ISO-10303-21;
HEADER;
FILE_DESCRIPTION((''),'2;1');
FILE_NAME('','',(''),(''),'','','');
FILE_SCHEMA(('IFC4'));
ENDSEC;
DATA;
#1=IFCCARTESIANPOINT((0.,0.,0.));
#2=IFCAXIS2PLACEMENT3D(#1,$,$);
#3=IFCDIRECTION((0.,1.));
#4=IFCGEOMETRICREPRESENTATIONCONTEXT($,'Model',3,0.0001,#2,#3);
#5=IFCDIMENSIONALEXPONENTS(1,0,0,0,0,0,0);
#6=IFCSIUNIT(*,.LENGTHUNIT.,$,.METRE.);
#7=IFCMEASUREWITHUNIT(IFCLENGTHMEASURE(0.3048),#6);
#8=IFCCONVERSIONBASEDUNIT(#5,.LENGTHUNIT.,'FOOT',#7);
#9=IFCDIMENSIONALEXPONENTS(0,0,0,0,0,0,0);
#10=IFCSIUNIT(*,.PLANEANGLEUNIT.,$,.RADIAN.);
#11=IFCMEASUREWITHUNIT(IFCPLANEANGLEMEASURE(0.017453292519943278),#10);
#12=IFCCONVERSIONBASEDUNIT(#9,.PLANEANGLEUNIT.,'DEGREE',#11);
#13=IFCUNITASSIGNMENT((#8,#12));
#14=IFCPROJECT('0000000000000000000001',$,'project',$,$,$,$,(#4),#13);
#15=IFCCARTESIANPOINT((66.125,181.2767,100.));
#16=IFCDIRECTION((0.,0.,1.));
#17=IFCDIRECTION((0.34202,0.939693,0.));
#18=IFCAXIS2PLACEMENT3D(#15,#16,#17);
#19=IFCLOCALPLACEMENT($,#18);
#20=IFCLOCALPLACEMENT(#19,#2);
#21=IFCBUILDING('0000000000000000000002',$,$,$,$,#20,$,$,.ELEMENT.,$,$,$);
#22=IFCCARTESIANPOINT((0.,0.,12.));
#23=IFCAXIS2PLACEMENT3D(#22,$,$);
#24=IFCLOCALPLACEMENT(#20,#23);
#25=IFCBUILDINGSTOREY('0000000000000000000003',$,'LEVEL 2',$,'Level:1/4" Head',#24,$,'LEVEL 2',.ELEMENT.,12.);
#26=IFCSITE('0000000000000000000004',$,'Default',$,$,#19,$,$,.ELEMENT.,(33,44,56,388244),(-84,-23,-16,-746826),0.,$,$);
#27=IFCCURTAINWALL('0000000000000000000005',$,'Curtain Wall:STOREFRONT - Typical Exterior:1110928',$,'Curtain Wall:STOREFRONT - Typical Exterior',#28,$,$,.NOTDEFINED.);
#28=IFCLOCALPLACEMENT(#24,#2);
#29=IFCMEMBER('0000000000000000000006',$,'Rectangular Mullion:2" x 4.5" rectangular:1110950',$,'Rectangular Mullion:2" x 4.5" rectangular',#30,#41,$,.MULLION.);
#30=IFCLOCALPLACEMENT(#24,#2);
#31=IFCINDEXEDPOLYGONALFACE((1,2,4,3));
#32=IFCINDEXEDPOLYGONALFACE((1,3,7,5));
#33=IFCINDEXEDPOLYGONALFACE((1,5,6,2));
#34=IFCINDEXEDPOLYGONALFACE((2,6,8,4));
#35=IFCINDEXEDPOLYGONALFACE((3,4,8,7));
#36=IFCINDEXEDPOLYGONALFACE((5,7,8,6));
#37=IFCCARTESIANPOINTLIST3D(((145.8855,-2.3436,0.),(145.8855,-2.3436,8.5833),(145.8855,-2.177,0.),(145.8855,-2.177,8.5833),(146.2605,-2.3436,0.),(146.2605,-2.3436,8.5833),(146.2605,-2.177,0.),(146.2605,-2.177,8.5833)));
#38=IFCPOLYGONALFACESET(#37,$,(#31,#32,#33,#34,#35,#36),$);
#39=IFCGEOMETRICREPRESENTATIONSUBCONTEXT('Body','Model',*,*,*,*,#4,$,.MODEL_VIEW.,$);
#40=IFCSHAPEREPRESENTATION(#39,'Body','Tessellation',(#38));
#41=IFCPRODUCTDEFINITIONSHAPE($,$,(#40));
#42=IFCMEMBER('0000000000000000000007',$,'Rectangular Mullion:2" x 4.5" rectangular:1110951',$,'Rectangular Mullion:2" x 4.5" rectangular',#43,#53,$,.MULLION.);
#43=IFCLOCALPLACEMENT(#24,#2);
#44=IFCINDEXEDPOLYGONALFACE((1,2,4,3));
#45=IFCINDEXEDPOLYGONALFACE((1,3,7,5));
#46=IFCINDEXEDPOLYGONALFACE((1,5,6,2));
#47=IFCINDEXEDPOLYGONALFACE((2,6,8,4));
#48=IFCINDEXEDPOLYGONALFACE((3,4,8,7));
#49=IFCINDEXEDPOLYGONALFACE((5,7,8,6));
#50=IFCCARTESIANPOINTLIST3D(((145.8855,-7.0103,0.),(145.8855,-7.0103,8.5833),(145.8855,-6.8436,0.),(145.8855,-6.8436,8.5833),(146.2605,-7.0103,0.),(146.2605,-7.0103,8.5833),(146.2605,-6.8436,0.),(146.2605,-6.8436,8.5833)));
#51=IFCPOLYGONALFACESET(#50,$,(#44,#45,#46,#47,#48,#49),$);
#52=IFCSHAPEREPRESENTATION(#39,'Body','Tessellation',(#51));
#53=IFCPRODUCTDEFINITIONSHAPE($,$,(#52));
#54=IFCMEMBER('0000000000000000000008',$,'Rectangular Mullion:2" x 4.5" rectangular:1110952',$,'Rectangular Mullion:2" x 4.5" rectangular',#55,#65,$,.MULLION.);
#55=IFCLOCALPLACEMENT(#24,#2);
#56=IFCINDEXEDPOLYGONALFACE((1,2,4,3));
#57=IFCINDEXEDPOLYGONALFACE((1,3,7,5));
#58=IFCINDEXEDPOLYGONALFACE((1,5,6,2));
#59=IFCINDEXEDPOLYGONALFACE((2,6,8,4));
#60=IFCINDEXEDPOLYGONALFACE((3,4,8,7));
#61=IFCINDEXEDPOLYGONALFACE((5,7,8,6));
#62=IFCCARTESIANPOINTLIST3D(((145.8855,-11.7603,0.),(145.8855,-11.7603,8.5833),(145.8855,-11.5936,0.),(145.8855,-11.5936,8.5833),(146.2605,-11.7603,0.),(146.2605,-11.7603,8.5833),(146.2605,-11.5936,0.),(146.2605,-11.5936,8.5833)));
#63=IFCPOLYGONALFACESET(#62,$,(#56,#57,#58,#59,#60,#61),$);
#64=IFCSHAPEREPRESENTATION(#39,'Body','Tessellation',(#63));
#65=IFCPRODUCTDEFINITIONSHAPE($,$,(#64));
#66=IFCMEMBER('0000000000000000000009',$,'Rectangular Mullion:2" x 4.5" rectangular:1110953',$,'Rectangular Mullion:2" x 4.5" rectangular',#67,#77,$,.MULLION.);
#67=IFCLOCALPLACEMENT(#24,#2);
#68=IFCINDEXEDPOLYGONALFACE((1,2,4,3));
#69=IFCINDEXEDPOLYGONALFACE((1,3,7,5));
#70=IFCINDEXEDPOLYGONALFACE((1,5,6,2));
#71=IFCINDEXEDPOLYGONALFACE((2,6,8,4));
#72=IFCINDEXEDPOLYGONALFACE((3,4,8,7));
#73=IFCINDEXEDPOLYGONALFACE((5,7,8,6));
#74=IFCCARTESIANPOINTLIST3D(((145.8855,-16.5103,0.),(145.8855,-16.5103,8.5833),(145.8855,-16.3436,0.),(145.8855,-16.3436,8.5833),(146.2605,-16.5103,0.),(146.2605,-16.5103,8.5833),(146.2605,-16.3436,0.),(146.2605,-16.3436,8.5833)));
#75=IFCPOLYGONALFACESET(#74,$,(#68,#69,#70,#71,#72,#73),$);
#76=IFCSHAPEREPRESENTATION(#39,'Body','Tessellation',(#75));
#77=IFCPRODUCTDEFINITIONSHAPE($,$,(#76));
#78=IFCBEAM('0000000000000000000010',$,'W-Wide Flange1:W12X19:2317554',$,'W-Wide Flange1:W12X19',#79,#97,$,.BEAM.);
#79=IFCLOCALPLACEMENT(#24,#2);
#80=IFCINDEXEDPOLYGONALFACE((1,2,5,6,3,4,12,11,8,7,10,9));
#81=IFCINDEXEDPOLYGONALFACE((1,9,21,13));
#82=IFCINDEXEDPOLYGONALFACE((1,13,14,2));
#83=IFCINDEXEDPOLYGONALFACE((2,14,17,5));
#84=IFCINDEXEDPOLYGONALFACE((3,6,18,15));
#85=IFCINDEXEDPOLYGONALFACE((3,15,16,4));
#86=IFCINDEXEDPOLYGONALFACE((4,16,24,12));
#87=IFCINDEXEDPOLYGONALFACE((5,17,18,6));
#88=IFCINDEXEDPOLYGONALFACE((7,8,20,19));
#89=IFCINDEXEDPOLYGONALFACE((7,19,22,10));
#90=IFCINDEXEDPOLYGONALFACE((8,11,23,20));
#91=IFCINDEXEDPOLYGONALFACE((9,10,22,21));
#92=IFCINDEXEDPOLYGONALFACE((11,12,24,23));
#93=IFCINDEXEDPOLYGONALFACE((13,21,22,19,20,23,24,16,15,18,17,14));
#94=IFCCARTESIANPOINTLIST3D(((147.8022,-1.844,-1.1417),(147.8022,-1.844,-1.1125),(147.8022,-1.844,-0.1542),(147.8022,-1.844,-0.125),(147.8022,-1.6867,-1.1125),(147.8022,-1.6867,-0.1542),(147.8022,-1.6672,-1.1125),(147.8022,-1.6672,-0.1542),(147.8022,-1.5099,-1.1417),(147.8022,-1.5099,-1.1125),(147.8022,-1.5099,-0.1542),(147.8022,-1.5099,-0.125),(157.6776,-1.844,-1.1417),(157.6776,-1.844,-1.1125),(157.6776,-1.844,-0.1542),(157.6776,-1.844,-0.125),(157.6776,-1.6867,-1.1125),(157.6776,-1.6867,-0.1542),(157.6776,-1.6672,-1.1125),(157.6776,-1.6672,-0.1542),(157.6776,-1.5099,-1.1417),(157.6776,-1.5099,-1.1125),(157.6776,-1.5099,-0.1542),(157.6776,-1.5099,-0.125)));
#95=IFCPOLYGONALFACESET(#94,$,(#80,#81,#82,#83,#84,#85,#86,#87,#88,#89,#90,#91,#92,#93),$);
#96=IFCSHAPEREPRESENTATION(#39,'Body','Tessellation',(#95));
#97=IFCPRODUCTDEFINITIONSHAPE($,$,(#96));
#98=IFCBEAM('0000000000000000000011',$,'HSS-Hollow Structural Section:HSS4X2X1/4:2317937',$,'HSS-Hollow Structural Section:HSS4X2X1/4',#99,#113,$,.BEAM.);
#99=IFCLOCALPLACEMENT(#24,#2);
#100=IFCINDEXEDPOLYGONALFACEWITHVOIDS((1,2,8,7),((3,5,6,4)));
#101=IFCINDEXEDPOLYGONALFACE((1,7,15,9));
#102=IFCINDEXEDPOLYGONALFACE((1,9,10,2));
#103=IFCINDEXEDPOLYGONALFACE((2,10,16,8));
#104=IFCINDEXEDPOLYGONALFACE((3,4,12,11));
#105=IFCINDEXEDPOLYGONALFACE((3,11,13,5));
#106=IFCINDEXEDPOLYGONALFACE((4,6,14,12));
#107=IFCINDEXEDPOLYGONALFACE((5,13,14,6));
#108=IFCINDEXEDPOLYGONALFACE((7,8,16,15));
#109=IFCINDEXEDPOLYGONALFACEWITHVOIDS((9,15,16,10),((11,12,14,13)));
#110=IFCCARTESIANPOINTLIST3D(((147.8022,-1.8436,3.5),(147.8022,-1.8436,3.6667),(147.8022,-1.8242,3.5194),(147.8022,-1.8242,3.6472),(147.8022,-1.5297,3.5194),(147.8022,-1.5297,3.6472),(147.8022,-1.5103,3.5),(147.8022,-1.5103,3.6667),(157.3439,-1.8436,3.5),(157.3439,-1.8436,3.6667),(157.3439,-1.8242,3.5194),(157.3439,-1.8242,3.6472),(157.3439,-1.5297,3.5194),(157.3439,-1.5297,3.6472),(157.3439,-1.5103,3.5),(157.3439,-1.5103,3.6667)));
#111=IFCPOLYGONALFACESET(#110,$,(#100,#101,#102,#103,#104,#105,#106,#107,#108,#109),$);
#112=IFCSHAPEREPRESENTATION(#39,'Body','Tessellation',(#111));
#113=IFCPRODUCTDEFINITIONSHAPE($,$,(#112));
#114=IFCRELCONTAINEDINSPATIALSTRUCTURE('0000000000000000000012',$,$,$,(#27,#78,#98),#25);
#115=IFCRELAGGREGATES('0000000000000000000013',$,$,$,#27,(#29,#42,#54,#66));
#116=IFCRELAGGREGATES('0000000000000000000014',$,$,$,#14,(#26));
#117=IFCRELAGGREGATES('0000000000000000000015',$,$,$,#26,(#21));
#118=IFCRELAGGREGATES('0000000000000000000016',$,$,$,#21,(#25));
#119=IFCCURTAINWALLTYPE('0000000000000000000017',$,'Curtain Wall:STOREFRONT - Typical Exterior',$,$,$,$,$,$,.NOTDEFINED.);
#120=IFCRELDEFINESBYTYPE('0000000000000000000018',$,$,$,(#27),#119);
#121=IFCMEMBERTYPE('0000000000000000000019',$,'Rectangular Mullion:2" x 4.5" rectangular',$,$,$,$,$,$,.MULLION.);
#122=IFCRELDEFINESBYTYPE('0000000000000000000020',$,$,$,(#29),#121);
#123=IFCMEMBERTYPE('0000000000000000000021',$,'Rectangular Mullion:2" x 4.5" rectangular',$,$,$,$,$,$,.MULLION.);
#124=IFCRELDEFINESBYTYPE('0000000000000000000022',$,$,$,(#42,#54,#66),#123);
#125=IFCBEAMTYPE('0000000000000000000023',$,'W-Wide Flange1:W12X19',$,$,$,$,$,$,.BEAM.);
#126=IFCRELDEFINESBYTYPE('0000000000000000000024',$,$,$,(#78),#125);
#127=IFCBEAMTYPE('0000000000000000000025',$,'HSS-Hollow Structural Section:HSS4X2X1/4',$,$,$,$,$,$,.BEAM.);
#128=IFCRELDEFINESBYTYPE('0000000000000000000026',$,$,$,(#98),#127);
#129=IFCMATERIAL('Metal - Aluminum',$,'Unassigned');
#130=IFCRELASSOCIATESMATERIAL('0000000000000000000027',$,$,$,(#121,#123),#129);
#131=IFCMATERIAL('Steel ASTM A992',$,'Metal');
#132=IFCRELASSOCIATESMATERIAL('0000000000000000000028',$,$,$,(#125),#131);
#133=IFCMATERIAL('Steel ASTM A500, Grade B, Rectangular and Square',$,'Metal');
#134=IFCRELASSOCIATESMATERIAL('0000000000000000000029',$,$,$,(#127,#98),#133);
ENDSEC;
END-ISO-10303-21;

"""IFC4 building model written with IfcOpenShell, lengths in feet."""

from ifc_helpers import new_model, entity, si_unit, converted_unit, direction, frame, frame_2d, origin, origin_2d_with_axis, place, context, subcontext, project, spatial, rectangle, i_section, extrude, boolean, source, transform, mapped, material, material_profile, profile_set, type_object, type_shapes, element, aggregate, save


model = new_model("IFC4")

# Units and contexts
model_context = context("Model", 3, precision=0.0001, world=origin(), true_north=direction((0.0, 1.0)))
body_context = subcontext(model_context, "Body", "Model", "MODEL_VIEW")
ifc_project = project(units=[converted_unit("LENGTHUNIT", "FOOT", entity("IfcLengthMeasure", 0.3048), si_unit("LENGTHUNIT", "METRE"), dimensions=[1, 0, 0, 0, 0, 0, 0]), converted_unit("PLANEANGLEUNIT", "DEGREE", entity("IfcPlaneAngleMeasure", 0.017453292519943278), si_unit("PLANEANGLEUNIT", "RADIAN"), dimensions=[0, 0, 0, 0, 0, 0, 0])], contexts=[model_context])

# Site, building, storey
site_placement = place(None, frame((66.125, 181.2767, 100.0), z_axis=(0.0, 0.0, 1.0), x_axis=(0.34202, 0.939693, 0.0)))
site = spatial("IfcSite", under=ifc_project, at=site_placement, Name="Default", CompositionType="ELEMENT", RefLatitude=(33, 44, 56, 388244), RefLongitude=(-84, -23, -16, -746826), RefElevation=0.0)
building_placement = place(site_placement, origin())
building = spatial("IfcBuilding", under=site, at=building_placement, CompositionType="ELEMENT")
storey_placement = place(building_placement, frame((0.0, 0.0, 12.0)))
storey = spatial("IfcBuildingStorey", under=building, at=storey_placement, Name="LEVEL 2", ObjectType="Level:1/4\" Head", LongName="LEVEL 2", CompositionType="ELEMENT", Elevation=12.0)

# Shared definitions
ifc_material_1 = material(Name="Steel ASTM A500, Grade B, Rectangular and Square", Category="Metal")

# Curtain wall
curtain_wall_type = type_object("IfcCurtainWallType", Name="Curtain Wall:STOREFRONT - Typical Exterior", PredefinedType="NOTDEFINED")
curtain_wall_1_placement = place(storey_placement, frame((0.0, 0.0, -12.0)))
curtain_wall_1 = element("IfcCurtainWall", 1, at=curtain_wall_1_placement, inside=storey, type_object=curtain_wall_type, Name="Curtain Wall:STOREFRONT - Typical Exterior:1110928", ObjectType="Curtain Wall:STOREFRONT - Typical Exterior", PredefinedType="NOTDEFINED")
ifc_material_2 = material(Name="Metal - Aluminum", Category="Unassigned")
ifc_material_profile_1 = material_profile(ifc_material_2, rectangle(XDim=0.1667, YDim=0.375, at=origin_2d_with_axis()), Name="2\" x 4.5\" rectangular")
ifc_profile_set_1 = profile_set([ifc_material_profile_1], Name="2\" x 4.5\" rectangular")

# Members
member_type_1 = type_object("IfcMemberType", Name="Rectangular Mullion:2\" x 4.5\" rectangular", PredefinedType="MULLION", material=ifc_profile_set_1)
shared_shape_1 = source(origin(), body_context, "Body", "SweptSolid", [
    extrude(rectangle(XDim=0.1667, YDim=0.375, at=origin_2d_with_axis()), frame((-0.0833, 0.0, -8.5833), z_axis=(0.0, 0.0, 1.0), x_axis=(-1.0, 0.0, 0.0)), (0.0, 0.0, 1.0), 8.5833),
])
type_shapes(member_type_1, [shared_shape_1])
member_1_placement = place(curtain_wall_1_placement, frame((146.073, -2.177, 20.5833), z_axis=(0.0, 0.0, 1.0), x_axis=(0.0, 1.0, 0.0)))
member_1 = element("IfcMember", 2, at=member_1_placement, type_object=member_type_1, Name="Rectangular Mullion:2\" x 4.5\" rectangular:1110950", ObjectType="Rectangular Mullion:2\" x 4.5\" rectangular", PredefinedType="MULLION", context=body_context, shape_type="MappedRepresentation", body=[
    mapped(shared_shape_1, transform((0.0, 0.0, 0.0), scale=1.0)),
])
member_type_2 = type_object("IfcMemberType", Name="Rectangular Mullion:2\" x 4.5\" rectangular", PredefinedType="MULLION", material=ifc_profile_set_1)
shared_shape_2 = source(origin(), body_context, "Body", "SweptSolid", [
    extrude(rectangle(XDim=0.1667, YDim=0.375, at=frame_2d((0.0, 0.0), x_axis=(1.0, 0.0))), frame((0.0, 0.0, -8.5833), z_axis=(0.0, 0.0, 1.0), x_axis=(-1.0, 0.0, 0.0)), (0.0, 0.0, 1.0), 8.5833),
])
type_shapes(member_type_2, [shared_shape_2])
member_2_placement = place(curtain_wall_1_placement, frame((146.073, -6.927, 12.0), z_axis=(0.0, 0.0, -1.0), x_axis=(0.0, -1.0, 0.0)))
member_2 = element("IfcMember", 3, at=member_2_placement, type_object=member_type_2, Name="Rectangular Mullion:2\" x 4.5\" rectangular:1110951", ObjectType="Rectangular Mullion:2\" x 4.5\" rectangular", PredefinedType="MULLION", context=body_context, shape_type="MappedRepresentation", body=[
    mapped(shared_shape_2, transform((0.0, 0.0, 0.0), scale=1.0)),
])
member_3_placement = place(curtain_wall_1_placement, frame((146.073, -11.677, 12.0), z_axis=(0.0, 0.0, -1.0), x_axis=(0.0, -1.0, 0.0)))
member_3 = element("IfcMember", 4, at=member_3_placement, type_object=member_type_2, Name="Rectangular Mullion:2\" x 4.5\" rectangular:1110952", ObjectType="Rectangular Mullion:2\" x 4.5\" rectangular", PredefinedType="MULLION", context=body_context, shape_type="MappedRepresentation", body=[
    mapped(shared_shape_2, transform((0.0, 0.0, 0.0), scale=1.0)),
])
member_4_placement = place(curtain_wall_1_placement, frame((146.073, -16.427, 12.0), z_axis=(0.0, 0.0, -1.0), x_axis=(0.0, -1.0, 0.0)))
member_4 = element("IfcMember", 5, at=member_4_placement, type_object=member_type_2, Name="Rectangular Mullion:2\" x 4.5\" rectangular:1110953", ObjectType="Rectangular Mullion:2\" x 4.5\" rectangular", PredefinedType="MULLION", context=body_context, shape_type="MappedRepresentation", body=[
    mapped(shared_shape_2, transform((0.0, 0.0, 0.0), scale=1.0)),
])

# Beam
ifc_material_3 = material(Name="Steel ASTM A992", Category="Metal")
ifc_material_profile_2 = material_profile(ifc_material_3, i_section(OverallWidth=0.3342, OverallDepth=1.0167, WebThickness=0.0196, FlangeThickness=0.0292, at=frame_2d((0.0, 0.0), x_axis=(0.0, 1.0))), Name="W12X19")
ifc_profile_set_2 = profile_set([ifc_material_profile_2], Name="W12X19")
beam_type_1 = type_object("IfcBeamType", Name="W-Wide Flange1:W12X19", PredefinedType="BEAM", material=ifc_profile_set_2)
shared_shape_3 = source(origin(), body_context, "Body", "SweptSolid", [
    extrude(i_section(OverallWidth=0.3342, OverallDepth=1.0167, WebThickness=0.0196, FlangeThickness=0.0292, at=frame_2d((0.0, 0.0), x_axis=(0.0, 1.0))), frame((-4.3333, 0.0, 0.0), z_axis=(1.0, 0.0, 0.0), x_axis=(0.0, 0.0, -1.0)), (0.0, 0.0, 1.0), 9.8754),
])
type_shapes(beam_type_1, [shared_shape_3])
beam_1_placement = place(storey_placement, frame((152.1355, -1.677, -0.6333)))
element("IfcBeam", 6, at=beam_1_placement, inside=storey, type_object=beam_type_1, Name="W-Wide Flange1:W12X19:2317554", ObjectType="W-Wide Flange1:W12X19", PredefinedType="BEAM", context=body_context, shape_type="MappedRepresentation", body=[
    mapped(shared_shape_3, transform((0.0, 0.0, 0.0), scale=1.0)),
])

# Beam
ifc_material_profile_3 = material_profile(ifc_material_1, rectangle(XDim=0.3333, YDim=0.1667, at=origin_2d_with_axis()), Name="HSS4X2X1/4")
ifc_profile_set_3 = profile_set([ifc_material_profile_3], Name="HSS4X2X1/4")
beam_type_2 = type_object("IfcBeamType", Name="HSS-Hollow Structural Section:HSS4X2X1/4", PredefinedType="BEAM", material=ifc_profile_set_3)
shared_shape_4 = source(origin(), body_context, "Body", "SweptSolid", [
    boolean("DIFFERENCE", extrude(rectangle(XDim=0.3333, YDim=0.1667, at=origin_2d_with_axis()), frame((-4.75, 0.0, 0.0), z_axis=(1.0, 0.0, 0.0), x_axis=(0.0, 0.0, -1.0)), (0.0, 0.0, 1.0), 9.5417), extrude(rectangle(XDim=0.2945, YDim=0.1278, at=frame_2d((0.0, 0.0), x_axis=(0.0, 1.0))), frame((4.7917, 0.0, 0.0), z_axis=(-1.0, 0.0, 0.0), x_axis=(0.0, 1.0, 0.0)), (0.0, 0.0, 1.0), 9.5417)),
])
type_shapes(beam_type_2, [shared_shape_4])
beam_2_placement = place(storey_placement, frame((152.5522, -1.677, 3.5833), z_axis=(0.0, 1.0, 0.0), x_axis=(1.0, 0.0, 0.0)))
element("IfcBeam", 7, at=beam_2_placement, inside=storey, type_object=beam_type_2, material=ifc_material_1, Name="HSS-Hollow Structural Section:HSS4X2X1/4:2317937", ObjectType="HSS-Hollow Structural Section:HSS4X2X1/4", PredefinedType="BEAM", context=body_context, shape_type="MappedRepresentation", body=[
    mapped(shared_shape_4, transform((0.0, 0.0, 0.0), scale=1.0)),
])

aggregate(curtain_wall_1, [member_1, member_2, member_3, member_4])

save(model, "model.ifc")
